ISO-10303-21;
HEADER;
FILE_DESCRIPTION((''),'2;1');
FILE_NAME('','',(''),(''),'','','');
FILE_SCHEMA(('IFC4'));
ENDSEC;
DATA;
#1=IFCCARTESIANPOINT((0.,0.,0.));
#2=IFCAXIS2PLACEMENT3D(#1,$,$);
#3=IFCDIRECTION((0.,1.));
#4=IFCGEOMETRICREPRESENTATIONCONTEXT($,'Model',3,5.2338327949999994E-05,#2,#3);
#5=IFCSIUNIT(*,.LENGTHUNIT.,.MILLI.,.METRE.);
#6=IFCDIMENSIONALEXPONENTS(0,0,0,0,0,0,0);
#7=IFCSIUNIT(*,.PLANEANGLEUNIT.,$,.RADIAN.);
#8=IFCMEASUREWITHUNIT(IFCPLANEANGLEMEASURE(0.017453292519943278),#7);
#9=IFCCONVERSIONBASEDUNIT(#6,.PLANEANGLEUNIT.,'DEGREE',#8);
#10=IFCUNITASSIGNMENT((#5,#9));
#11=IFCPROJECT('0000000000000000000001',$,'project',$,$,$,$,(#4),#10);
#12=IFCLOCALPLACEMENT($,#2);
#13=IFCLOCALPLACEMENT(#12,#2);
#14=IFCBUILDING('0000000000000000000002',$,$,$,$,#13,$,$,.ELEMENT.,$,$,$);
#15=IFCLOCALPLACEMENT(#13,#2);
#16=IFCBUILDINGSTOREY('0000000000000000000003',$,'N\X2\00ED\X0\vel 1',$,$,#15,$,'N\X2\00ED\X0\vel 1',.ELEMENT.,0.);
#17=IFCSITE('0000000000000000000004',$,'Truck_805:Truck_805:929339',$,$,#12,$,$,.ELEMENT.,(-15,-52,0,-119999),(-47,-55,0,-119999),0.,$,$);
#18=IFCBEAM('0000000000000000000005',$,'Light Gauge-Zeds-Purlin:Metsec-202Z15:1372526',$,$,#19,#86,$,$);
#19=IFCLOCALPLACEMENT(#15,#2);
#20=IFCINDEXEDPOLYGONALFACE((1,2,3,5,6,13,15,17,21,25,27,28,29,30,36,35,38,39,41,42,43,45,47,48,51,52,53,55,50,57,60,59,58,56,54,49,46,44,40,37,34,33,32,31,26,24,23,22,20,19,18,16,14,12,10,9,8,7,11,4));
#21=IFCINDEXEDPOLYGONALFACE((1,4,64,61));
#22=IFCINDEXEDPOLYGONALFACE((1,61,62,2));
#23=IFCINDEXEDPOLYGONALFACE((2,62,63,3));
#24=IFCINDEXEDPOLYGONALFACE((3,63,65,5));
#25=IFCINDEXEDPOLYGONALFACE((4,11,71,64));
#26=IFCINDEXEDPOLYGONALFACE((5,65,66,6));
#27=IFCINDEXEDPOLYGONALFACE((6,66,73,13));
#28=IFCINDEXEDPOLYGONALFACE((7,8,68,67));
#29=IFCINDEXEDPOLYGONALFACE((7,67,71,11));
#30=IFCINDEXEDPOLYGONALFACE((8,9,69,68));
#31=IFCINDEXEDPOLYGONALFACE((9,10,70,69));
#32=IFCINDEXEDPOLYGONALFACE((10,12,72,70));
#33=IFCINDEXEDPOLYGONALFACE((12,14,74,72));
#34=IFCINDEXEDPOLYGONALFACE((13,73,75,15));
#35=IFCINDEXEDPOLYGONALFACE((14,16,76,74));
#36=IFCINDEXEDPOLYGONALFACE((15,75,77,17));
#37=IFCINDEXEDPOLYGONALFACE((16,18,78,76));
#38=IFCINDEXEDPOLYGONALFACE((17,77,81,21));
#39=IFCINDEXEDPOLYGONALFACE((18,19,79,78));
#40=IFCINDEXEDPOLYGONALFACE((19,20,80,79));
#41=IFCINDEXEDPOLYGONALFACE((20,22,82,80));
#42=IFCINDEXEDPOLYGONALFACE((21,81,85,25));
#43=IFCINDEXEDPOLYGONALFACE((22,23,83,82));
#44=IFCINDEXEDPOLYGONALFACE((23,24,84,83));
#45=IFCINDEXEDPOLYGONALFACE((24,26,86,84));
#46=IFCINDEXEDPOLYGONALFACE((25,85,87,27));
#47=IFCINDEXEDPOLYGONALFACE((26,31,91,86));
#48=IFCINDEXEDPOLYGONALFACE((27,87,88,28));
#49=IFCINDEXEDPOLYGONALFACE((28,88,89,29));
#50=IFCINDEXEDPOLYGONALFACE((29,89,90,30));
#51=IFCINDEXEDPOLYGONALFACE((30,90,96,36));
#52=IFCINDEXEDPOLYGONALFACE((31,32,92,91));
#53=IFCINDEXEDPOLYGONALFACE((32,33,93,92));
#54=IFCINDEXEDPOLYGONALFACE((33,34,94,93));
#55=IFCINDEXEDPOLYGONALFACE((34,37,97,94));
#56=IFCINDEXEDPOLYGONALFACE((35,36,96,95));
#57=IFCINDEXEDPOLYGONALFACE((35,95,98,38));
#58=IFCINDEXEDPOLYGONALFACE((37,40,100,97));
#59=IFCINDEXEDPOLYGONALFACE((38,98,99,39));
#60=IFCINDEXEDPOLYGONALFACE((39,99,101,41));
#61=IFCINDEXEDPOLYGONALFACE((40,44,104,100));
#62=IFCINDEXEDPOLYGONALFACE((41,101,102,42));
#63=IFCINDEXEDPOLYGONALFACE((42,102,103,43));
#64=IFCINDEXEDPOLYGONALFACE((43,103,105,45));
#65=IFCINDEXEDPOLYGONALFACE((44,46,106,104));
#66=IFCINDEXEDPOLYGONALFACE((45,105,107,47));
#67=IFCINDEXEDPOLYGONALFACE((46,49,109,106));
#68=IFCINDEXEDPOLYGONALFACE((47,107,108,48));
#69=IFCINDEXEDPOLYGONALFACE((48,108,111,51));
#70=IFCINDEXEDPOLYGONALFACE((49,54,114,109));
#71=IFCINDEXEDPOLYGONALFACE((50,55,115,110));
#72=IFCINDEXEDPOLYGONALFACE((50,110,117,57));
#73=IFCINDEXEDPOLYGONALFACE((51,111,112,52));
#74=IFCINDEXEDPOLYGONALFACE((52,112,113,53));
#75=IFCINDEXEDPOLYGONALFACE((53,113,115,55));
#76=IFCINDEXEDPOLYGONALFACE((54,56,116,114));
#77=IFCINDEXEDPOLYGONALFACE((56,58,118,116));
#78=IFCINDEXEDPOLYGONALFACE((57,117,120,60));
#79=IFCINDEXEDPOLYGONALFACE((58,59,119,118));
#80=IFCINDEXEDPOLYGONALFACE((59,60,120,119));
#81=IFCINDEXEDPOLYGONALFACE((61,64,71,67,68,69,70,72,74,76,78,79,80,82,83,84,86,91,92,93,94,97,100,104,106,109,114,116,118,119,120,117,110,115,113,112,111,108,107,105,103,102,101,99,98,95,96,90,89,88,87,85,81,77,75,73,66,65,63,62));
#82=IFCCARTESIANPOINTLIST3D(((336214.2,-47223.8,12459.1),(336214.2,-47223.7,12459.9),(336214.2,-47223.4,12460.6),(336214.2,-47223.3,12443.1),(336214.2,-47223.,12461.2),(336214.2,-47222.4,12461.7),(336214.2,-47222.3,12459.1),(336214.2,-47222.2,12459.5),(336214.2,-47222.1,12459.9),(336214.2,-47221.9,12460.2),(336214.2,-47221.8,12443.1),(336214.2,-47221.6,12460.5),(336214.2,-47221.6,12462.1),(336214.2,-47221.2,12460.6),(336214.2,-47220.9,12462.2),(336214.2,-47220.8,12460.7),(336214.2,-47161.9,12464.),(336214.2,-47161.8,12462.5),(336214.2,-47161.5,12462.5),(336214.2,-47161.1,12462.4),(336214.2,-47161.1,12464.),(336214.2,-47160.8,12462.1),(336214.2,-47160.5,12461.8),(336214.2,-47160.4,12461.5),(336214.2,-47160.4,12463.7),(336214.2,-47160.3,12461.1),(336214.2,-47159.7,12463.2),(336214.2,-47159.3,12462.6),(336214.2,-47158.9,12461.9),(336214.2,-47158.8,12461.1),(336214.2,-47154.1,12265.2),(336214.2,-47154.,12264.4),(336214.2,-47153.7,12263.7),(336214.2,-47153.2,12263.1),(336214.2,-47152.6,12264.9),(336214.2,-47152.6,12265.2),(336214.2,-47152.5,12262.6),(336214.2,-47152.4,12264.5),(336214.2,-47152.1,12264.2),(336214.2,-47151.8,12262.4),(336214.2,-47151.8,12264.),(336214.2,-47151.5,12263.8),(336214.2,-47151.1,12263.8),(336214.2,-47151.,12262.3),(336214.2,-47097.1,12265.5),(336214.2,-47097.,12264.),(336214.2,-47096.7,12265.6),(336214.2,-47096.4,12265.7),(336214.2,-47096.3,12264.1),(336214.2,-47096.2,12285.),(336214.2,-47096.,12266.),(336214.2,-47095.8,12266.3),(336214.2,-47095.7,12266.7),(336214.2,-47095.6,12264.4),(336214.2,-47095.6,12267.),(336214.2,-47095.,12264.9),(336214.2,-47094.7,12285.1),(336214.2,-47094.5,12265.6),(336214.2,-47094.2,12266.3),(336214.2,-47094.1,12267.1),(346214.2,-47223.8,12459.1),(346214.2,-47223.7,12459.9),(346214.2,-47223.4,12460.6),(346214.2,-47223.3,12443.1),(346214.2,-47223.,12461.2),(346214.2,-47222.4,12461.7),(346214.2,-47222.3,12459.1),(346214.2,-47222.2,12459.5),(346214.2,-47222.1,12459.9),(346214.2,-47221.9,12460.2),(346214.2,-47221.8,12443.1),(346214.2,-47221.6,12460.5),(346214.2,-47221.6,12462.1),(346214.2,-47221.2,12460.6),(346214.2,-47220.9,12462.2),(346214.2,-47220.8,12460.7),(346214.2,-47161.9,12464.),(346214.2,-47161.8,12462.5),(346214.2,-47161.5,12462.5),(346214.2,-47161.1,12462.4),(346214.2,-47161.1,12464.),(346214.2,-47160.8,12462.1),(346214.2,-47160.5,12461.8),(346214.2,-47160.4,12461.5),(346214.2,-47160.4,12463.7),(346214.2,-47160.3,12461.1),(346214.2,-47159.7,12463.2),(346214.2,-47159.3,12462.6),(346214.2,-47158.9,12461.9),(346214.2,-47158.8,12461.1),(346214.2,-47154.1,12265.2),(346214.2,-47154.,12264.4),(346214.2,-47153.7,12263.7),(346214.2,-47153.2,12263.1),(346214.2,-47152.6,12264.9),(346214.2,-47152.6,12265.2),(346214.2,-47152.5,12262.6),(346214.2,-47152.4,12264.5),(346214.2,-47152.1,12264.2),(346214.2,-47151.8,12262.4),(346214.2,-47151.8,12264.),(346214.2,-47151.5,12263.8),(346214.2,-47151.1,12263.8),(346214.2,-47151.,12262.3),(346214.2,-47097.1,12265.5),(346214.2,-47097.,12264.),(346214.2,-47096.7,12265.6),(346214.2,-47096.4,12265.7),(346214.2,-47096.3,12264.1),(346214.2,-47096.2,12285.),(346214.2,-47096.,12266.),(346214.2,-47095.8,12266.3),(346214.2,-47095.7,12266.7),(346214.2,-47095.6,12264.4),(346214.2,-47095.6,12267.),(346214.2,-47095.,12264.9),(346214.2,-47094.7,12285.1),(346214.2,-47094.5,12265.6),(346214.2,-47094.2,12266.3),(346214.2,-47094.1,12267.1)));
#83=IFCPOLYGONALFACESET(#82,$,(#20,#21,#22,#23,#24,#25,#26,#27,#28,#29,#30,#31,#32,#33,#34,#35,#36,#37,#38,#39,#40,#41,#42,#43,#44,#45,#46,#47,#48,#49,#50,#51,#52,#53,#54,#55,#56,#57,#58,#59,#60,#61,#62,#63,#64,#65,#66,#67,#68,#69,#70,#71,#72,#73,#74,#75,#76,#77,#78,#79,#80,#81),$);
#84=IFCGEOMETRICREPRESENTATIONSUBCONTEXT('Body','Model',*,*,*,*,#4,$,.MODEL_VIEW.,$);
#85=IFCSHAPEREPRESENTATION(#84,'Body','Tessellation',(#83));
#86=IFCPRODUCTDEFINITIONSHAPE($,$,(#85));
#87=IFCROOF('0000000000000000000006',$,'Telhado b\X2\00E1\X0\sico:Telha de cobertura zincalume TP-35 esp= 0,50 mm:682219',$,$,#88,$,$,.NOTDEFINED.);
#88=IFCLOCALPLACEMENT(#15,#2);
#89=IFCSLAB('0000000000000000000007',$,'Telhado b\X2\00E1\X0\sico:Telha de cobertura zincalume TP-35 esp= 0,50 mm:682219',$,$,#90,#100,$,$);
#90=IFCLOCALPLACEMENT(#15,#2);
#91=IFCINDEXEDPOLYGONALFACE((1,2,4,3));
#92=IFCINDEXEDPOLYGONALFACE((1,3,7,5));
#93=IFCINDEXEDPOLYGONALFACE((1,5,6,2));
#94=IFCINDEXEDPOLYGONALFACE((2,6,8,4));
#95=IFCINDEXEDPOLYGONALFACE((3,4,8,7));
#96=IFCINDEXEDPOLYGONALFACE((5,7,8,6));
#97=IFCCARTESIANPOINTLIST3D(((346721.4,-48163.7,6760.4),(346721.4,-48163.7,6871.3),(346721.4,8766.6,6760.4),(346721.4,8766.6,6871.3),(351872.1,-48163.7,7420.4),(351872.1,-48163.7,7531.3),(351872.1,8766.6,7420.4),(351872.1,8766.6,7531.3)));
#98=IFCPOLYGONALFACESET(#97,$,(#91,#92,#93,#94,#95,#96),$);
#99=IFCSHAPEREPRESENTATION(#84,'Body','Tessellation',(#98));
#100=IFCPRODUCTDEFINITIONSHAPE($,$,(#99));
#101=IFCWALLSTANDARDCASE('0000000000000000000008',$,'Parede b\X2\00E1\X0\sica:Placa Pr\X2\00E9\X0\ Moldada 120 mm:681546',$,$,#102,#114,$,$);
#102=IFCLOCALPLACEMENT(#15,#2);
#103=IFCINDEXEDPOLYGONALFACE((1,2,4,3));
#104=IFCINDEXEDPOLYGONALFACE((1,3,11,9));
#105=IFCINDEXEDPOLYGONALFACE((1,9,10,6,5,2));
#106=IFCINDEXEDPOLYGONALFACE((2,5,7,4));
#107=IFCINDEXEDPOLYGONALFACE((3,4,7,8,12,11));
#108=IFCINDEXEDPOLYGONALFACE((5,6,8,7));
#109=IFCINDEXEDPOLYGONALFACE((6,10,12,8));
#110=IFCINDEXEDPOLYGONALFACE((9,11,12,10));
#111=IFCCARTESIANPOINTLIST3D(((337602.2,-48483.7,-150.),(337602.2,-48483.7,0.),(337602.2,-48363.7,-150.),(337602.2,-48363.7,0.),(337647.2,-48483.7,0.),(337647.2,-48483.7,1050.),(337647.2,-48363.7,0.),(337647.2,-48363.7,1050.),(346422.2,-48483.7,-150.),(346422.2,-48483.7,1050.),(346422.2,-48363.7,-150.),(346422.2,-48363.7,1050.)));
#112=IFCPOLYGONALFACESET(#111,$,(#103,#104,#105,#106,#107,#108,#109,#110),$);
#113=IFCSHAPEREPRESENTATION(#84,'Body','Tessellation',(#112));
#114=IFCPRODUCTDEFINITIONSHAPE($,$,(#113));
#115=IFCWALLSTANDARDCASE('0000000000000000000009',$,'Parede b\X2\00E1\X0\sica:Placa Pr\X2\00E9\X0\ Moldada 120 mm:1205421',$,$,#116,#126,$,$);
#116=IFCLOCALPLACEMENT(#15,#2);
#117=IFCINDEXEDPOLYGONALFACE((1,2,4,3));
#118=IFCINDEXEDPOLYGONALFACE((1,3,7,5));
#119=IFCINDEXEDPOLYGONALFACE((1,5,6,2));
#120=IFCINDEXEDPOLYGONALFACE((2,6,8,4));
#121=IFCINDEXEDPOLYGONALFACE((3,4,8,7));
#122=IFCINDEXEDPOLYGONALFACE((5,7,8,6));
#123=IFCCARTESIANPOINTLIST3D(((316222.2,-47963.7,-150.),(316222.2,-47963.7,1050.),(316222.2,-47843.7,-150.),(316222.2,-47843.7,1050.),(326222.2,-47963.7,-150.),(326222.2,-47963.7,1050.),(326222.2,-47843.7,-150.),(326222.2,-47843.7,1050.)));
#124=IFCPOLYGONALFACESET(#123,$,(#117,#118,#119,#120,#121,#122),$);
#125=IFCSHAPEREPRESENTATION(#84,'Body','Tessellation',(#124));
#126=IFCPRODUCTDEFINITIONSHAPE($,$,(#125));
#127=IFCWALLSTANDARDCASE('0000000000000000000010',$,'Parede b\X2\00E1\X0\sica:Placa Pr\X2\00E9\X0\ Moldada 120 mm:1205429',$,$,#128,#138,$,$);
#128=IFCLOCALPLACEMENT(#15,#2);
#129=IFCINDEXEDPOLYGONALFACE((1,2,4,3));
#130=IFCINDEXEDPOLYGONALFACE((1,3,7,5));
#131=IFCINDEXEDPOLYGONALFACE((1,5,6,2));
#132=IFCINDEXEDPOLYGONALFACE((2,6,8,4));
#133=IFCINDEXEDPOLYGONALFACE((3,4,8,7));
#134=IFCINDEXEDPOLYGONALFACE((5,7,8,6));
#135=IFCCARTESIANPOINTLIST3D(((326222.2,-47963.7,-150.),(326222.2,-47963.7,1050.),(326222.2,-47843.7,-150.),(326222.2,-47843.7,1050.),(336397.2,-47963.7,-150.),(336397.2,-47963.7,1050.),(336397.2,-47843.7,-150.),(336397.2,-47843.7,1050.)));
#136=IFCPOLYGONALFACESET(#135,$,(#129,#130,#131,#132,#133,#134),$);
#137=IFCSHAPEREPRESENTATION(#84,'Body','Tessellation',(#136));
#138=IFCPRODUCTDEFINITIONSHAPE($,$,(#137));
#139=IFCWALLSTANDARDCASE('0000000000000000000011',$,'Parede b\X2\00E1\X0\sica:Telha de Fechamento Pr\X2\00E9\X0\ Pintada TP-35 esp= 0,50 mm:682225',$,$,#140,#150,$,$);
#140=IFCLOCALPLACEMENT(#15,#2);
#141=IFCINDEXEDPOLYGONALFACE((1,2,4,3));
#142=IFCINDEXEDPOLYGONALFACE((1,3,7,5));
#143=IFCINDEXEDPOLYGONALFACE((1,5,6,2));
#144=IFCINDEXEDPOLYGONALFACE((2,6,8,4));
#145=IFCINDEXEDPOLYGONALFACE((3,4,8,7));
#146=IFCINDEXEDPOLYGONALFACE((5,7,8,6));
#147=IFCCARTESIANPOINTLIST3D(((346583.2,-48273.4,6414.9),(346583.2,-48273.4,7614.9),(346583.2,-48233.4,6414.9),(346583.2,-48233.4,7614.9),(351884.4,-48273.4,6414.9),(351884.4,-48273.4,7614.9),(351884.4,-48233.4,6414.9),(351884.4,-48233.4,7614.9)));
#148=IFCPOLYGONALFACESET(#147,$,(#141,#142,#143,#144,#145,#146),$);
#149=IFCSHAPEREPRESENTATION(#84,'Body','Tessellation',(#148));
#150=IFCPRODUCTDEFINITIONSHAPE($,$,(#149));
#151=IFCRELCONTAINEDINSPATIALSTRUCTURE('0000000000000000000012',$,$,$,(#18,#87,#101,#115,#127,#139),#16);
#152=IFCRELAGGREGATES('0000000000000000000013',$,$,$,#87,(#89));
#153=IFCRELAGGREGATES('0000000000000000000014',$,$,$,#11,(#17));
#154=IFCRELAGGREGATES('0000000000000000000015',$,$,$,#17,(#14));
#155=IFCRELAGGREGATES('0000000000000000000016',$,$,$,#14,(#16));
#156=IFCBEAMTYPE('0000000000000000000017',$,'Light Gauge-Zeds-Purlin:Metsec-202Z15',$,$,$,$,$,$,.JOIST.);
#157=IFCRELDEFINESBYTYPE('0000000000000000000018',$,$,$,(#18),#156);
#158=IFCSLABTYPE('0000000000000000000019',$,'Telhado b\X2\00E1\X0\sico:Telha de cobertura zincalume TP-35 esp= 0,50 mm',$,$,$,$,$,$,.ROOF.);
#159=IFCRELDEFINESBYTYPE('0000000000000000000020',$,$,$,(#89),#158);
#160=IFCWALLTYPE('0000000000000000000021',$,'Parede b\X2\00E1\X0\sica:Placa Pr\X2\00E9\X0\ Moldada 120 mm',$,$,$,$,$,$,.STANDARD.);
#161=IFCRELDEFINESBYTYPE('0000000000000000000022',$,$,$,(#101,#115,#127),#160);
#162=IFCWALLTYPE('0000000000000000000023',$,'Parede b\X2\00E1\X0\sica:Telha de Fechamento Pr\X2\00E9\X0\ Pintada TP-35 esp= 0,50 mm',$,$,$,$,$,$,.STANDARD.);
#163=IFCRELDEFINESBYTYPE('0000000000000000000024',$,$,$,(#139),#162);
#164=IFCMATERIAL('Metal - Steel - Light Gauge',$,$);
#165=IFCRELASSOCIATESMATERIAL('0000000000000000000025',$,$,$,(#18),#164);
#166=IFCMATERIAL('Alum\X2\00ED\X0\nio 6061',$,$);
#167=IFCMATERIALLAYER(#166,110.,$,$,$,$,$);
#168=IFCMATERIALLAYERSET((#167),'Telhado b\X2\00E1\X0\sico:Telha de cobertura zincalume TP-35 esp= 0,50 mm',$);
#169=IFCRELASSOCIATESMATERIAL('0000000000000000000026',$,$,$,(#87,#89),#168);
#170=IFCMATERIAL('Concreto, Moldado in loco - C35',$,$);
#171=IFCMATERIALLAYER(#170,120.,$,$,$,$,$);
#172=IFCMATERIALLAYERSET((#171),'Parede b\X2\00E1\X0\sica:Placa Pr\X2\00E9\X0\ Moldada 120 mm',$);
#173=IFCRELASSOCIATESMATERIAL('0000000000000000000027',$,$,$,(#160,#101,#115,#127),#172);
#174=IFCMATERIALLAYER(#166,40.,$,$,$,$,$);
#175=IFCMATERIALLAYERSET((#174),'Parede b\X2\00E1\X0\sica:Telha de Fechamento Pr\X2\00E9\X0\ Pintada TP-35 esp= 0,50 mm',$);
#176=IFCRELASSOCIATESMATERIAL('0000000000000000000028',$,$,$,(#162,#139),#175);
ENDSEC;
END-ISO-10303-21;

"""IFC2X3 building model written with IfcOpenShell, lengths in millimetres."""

from ifc_helpers import new_model, entity, si_unit, converted_unit, direction, frame, frame_2d, origin, place, context, subcontext, project, spatial, polyline, circle_curve, parameter, trimmed, segment, composite_curve, rectangle, outline, extrude, material, layer, layer_set, layer_usage, type_object, element, aggregate, save


model = new_model("IFC2X3")

# Units and contexts
model_context = context("Model", 3, precision=5.2338327949999994e-05, world=origin(), true_north=direction((0.0, 1.0)))
body_context = subcontext(model_context, "Body", "Model", "MODEL_VIEW")
ifc_project = project(units=[si_unit("LENGTHUNIT", "METRE", prefix="MILLI"), converted_unit("PLANEANGLEUNIT", "DEGREE", entity("IfcPlaneAngleMeasure", 0.017453292519943278), si_unit("PLANEANGLEUNIT", "RADIAN"), dimensions=[0, 0, 0, 0, 0, 0, 0])], contexts=[model_context])

# Site, building, storey
site_placement = place(None, origin())
site = spatial("IfcSite", under=ifc_project, at=site_placement, Name="Truck_805:Truck_805:929339", CompositionType="ELEMENT", RefLatitude=(-15, -52, 0, -119999), RefLongitude=(-47, -55, 0, -119999), RefElevation=0.0)
building_placement = place(site_placement, origin())
building = spatial("IfcBuilding", under=site, at=building_placement, CompositionType="ELEMENT")
storey_placement = place(building_placement, origin())
storey = spatial("IfcBuildingStorey", under=building, at=storey_placement, Name="Nível 1", LongName="Nível 1", CompositionType="ELEMENT", Elevation=0.0)

# Beam
ifc_material_1 = material(Name="Metal - Steel - Light Gauge")
beam_type_1 = type_object("IfcBeamType", Name="Light Gauge-Zeds-Purlin:Metsec-202Z15", PredefinedType="JOIST")
beam_1_placement = place(storey_placement, frame((336214.2, -47154.0, 12262.2)))
element("IfcBeam", 1, at=beam_1_placement, inside=storey, type_object=beam_type_1, material=ifc_material_1, Name="Light Gauge-Zeds-Purlin:Metsec-202Z15:1372526", context=body_context, shape_type="SweptSolid", body=[
    extrude(outline(composite_curve([segment(trimmed(circle_curve(frame_2d((98.2, 57.8), x_axis=(1.0, 0.0)), 3.0), [parameter(0.0)], [parameter(90.0)], True, "PARAMETER"), True, "CONTINUOUS"), segment(polyline([(98.2, 60.8), (80.2, 60.8)]), True, "CONTINUOUS"), segment(polyline([(80.2, 60.8), (80.2, 59.3)]), True, "CONTINUOUS"), segment(polyline([(80.2, 59.3), (98.2, 59.3)]), True, "CONTINUOUS"), segment(trimmed(circle_curve(frame_2d((98.2, 57.8), x_axis=(0.0, 1.0)), 1.5), [parameter(270.0)], [parameter(0.0)], True, "PARAMETER"), False, "CONTINUOUS"), segment(polyline([(99.7, 57.8), (99.7, 3.8)]), True, "CONTINUOUS"), segment(trimmed(circle_curve(frame_2d((98.2, 3.8), x_axis=(1.0, 0.0)), 1.5), [parameter(270.0)], [parameter(0.0)], True, "PARAMETER"), False, "CONTINUOUS"), segment(polyline([(98.2, 2.3), (-97.8, 2.2)]), True, "CONTINUOUS"), segment(trimmed(circle_curve(frame_2d((-97.8, -0.8), x_axis=(0.0, 1.0)), 3.0), [parameter(0.0)], [parameter(90.0)], True, "PARAMETER"), True, "CONTINUOUS"), segment(polyline([(-100.8, -0.8), (-100.8, -59.8)]), True, "CONTINUOUS"), segment(trimmed(circle_curve(frame_2d((-97.8, -59.8), x_axis=(-1.0, 0.0)), 3.0), [parameter(0.0)], [parameter(90.0)], True, "PARAMETER"), True, "CONTINUOUS"), segment(polyline([(-97.8, -62.8), (-81.8, -62.8)]), True, "CONTINUOUS"), segment(polyline([(-81.8, -62.8), (-81.8, -61.3)]), True, "CONTINUOUS"), segment(polyline([(-81.8, -61.3), (-97.8, -61.3)]), True, "CONTINUOUS"), segment(trimmed(circle_curve(frame_2d((-97.8, -59.8), x_axis=(0.0, -1.0)), 1.5), [parameter(270.0)], [parameter(0.0)], True, "PARAMETER"), False, "CONTINUOUS"), segment(polyline([(-99.3, -59.8), (-99.3, -0.8)]), True, "CONTINUOUS"), segment(trimmed(circle_curve(frame_2d((-97.8, -0.8), x_axis=(-1.0, 0.0)), 1.5), [parameter(270.0)], [parameter(0.0)], True, "PARAMETER"), False, "CONTINUOUS"), segment(polyline([(-97.8, 0.7), (98.2, 0.8)]), True, "CONTINUOUS"), segment(trimmed(circle_curve(frame_2d((98.2, 3.8), x_axis=(0.0, -1.0)), 3.0), [parameter(0.0)], [parameter(90.0)], True, "PARAMETER"), True, "CONTINUOUS"), segment(polyline([(101.2, 3.8), (101.2, 57.8)]), True, "CONTINUOUS")], self_intersect=False)), frame((0.0, -3.9, 101.1), z_axis=(1.0, 0.0, 0.0), x_axis=(0.0, 0.031563, -0.999502)), (0.0, 0.0, 1.0), 10000.0),
])

# Roof, slab
ifc_material_2 = material(Name="Alumínio 6061")
ifc_layer_1 = layer(ifc_material_2, 110.0)
ifc_layer_set_1 = layer_set([ifc_layer_1], Name="Telhado básico:Telha de cobertura zincalume TP-35 esp= 0,50 mm")
roof_placement = place(storey_placement, frame((346721.4, -48163.7, 6760.4)))
roof = element("IfcRoof", 2, at=roof_placement, inside=storey, material=ifc_layer_set_1, Name="Telhado básico:Telha de cobertura zincalume TP-35 esp= 0,50 mm:682219", ShapeType="NOTDEFINED")
slab_type = type_object("IfcSlabType", Name="Telhado básico:Telha de cobertura zincalume TP-35 esp= 0,50 mm", PredefinedType="ROOF")
slab_placement = place(roof_placement, origin())
slab = element("IfcSlab", 3, at=slab_placement, type_object=slab_type, material=ifc_layer_set_1, Name="Telhado básico:Telha de cobertura zincalume TP-35 esp= 0,50 mm:682219", context=body_context, shape_type="SweptSolid", body=[
    extrude(rectangle(XDim=56930.3, YDim=5192.8, at=frame_2d((0.0, 0.0), x_axis=(0.0, 1.0))), frame((2575.4, 28465.2, 330.0), z_axis=(-0.127099, 0.0, 0.99189), x_axis=(0.99189, 0.0, 0.127099)), (0.127099, 0.0, 0.99189), 110.9),
])
aggregate(roof, [slab])

# Wall, opening
ifc_material_3 = material(Name="Concreto, Moldado in loco - C35")
ifc_layer_2 = layer(ifc_material_3, 120.0)
ifc_layer_set_2 = layer_set([ifc_layer_2], Name="Parede básica:Placa Pré Moldada 120 mm")
ifc_layer_usage_1 = layer_usage(ifc_layer_set_2, "AXIS2", "POSITIVE", -60.0)
wall_type_1 = type_object("IfcWallType", Name="Parede básica:Placa Pré Moldada 120 mm", PredefinedType="STANDARD", material=ifc_layer_set_2)
wall_1_placement = place(storey_placement, frame((337602.2, -48423.7, -150.0)))
wall_1 = element("IfcWallStandardCase", 4, at=wall_1_placement, inside=storey, type_object=wall_type_1, material=ifc_layer_usage_1, Name="Parede básica:Placa Pré Moldada 120 mm:681546", context=body_context, shape_type="SweptSolid", body=[
    extrude(rectangle(XDim=8820.0, YDim=120.0, at=frame_2d((4410.0, 0.0), x_axis=(-1.0, 0.0))), origin(), (0.0, 0.0, 1.0), 1200.0),
])
opening_placement = place(wall_1_placement, frame((45.0, 60.0, 150.0)))
element("IfcOpeningElement", 5, at=opening_placement, cuts=wall_1, ObjectType="Opening", context=body_context, shape_type="SweptSolid", body=[
    extrude(rectangle(XDim=2200.0, YDim=1200.0, at=frame_2d((1100.0, 600.0), x_axis=(-1.0, 0.0))), frame((0.0, 0.0, 0.0), z_axis=(0.0, -1.0, 0.0), x_axis=(0.0, 0.0, 1.0)), (0.0, 0.0, 1.0), 120.0),
])

# Walls
ifc_layer_usage_2 = layer_usage(ifc_layer_set_2, "AXIS2", "POSITIVE", -60.0)
wall_2_placement = place(storey_placement, frame((316222.2, -47903.7, -150.0)))
element("IfcWallStandardCase", 6, at=wall_2_placement, inside=storey, type_object=wall_type_1, material=ifc_layer_usage_2, Name="Parede básica:Placa Pré Moldada 120 mm:1205421", context=body_context, shape_type="SweptSolid", body=[
    extrude(rectangle(XDim=10000.0, YDim=120.0, at=frame_2d((5000.0, 0.0), x_axis=(-1.0, 0.0))), origin(), (0.0, 0.0, 1.0), 1200.0),
])
ifc_layer_usage_3 = layer_usage(ifc_layer_set_2, "AXIS2", "POSITIVE", -60.0)
wall_3_placement = place(storey_placement, frame((326222.2, -47903.7, -150.0)))
element("IfcWallStandardCase", 7, at=wall_3_placement, inside=storey, type_object=wall_type_1, material=ifc_layer_usage_3, Name="Parede básica:Placa Pré Moldada 120 mm:1205429", context=body_context, shape_type="SweptSolid", body=[
    extrude(rectangle(XDim=10175.0, YDim=120.0, at=frame_2d((5087.5, 0.0), x_axis=(-1.0, 0.0))), origin(), (0.0, 0.0, 1.0), 1200.0),
])
ifc_layer_3 = layer(ifc_material_2, 40.0)
ifc_layer_set_3 = layer_set([ifc_layer_3], Name="Parede básica:Telha de Fechamento Pré Pintada TP-35 esp= 0,50 mm")
ifc_layer_usage_4 = layer_usage(ifc_layer_set_3, "AXIS2", "POSITIVE", -20.0)
wall_type_2 = type_object("IfcWallType", Name="Parede básica:Telha de Fechamento Pré Pintada TP-35 esp= 0,50 mm", PredefinedType="STANDARD", material=ifc_layer_set_3)
wall_4_placement = place(storey_placement, frame((346583.2, -48253.4, 6414.9)))
element("IfcWallStandardCase", 8, at=wall_4_placement, inside=storey, type_object=wall_type_2, material=ifc_layer_usage_4, Name="Parede básica:Telha de Fechamento Pré Pintada TP-35 esp= 0,50 mm:682225", context=body_context, shape_type="SweptSolid", body=[
    extrude(rectangle(XDim=5301.2, YDim=40.0, at=frame_2d((2650.6, 0.0), x_axis=(-1.0, 0.0))), origin(), (0.0, 0.0, 1.0), 1200.0),
])

save(model, "model.ifc")
